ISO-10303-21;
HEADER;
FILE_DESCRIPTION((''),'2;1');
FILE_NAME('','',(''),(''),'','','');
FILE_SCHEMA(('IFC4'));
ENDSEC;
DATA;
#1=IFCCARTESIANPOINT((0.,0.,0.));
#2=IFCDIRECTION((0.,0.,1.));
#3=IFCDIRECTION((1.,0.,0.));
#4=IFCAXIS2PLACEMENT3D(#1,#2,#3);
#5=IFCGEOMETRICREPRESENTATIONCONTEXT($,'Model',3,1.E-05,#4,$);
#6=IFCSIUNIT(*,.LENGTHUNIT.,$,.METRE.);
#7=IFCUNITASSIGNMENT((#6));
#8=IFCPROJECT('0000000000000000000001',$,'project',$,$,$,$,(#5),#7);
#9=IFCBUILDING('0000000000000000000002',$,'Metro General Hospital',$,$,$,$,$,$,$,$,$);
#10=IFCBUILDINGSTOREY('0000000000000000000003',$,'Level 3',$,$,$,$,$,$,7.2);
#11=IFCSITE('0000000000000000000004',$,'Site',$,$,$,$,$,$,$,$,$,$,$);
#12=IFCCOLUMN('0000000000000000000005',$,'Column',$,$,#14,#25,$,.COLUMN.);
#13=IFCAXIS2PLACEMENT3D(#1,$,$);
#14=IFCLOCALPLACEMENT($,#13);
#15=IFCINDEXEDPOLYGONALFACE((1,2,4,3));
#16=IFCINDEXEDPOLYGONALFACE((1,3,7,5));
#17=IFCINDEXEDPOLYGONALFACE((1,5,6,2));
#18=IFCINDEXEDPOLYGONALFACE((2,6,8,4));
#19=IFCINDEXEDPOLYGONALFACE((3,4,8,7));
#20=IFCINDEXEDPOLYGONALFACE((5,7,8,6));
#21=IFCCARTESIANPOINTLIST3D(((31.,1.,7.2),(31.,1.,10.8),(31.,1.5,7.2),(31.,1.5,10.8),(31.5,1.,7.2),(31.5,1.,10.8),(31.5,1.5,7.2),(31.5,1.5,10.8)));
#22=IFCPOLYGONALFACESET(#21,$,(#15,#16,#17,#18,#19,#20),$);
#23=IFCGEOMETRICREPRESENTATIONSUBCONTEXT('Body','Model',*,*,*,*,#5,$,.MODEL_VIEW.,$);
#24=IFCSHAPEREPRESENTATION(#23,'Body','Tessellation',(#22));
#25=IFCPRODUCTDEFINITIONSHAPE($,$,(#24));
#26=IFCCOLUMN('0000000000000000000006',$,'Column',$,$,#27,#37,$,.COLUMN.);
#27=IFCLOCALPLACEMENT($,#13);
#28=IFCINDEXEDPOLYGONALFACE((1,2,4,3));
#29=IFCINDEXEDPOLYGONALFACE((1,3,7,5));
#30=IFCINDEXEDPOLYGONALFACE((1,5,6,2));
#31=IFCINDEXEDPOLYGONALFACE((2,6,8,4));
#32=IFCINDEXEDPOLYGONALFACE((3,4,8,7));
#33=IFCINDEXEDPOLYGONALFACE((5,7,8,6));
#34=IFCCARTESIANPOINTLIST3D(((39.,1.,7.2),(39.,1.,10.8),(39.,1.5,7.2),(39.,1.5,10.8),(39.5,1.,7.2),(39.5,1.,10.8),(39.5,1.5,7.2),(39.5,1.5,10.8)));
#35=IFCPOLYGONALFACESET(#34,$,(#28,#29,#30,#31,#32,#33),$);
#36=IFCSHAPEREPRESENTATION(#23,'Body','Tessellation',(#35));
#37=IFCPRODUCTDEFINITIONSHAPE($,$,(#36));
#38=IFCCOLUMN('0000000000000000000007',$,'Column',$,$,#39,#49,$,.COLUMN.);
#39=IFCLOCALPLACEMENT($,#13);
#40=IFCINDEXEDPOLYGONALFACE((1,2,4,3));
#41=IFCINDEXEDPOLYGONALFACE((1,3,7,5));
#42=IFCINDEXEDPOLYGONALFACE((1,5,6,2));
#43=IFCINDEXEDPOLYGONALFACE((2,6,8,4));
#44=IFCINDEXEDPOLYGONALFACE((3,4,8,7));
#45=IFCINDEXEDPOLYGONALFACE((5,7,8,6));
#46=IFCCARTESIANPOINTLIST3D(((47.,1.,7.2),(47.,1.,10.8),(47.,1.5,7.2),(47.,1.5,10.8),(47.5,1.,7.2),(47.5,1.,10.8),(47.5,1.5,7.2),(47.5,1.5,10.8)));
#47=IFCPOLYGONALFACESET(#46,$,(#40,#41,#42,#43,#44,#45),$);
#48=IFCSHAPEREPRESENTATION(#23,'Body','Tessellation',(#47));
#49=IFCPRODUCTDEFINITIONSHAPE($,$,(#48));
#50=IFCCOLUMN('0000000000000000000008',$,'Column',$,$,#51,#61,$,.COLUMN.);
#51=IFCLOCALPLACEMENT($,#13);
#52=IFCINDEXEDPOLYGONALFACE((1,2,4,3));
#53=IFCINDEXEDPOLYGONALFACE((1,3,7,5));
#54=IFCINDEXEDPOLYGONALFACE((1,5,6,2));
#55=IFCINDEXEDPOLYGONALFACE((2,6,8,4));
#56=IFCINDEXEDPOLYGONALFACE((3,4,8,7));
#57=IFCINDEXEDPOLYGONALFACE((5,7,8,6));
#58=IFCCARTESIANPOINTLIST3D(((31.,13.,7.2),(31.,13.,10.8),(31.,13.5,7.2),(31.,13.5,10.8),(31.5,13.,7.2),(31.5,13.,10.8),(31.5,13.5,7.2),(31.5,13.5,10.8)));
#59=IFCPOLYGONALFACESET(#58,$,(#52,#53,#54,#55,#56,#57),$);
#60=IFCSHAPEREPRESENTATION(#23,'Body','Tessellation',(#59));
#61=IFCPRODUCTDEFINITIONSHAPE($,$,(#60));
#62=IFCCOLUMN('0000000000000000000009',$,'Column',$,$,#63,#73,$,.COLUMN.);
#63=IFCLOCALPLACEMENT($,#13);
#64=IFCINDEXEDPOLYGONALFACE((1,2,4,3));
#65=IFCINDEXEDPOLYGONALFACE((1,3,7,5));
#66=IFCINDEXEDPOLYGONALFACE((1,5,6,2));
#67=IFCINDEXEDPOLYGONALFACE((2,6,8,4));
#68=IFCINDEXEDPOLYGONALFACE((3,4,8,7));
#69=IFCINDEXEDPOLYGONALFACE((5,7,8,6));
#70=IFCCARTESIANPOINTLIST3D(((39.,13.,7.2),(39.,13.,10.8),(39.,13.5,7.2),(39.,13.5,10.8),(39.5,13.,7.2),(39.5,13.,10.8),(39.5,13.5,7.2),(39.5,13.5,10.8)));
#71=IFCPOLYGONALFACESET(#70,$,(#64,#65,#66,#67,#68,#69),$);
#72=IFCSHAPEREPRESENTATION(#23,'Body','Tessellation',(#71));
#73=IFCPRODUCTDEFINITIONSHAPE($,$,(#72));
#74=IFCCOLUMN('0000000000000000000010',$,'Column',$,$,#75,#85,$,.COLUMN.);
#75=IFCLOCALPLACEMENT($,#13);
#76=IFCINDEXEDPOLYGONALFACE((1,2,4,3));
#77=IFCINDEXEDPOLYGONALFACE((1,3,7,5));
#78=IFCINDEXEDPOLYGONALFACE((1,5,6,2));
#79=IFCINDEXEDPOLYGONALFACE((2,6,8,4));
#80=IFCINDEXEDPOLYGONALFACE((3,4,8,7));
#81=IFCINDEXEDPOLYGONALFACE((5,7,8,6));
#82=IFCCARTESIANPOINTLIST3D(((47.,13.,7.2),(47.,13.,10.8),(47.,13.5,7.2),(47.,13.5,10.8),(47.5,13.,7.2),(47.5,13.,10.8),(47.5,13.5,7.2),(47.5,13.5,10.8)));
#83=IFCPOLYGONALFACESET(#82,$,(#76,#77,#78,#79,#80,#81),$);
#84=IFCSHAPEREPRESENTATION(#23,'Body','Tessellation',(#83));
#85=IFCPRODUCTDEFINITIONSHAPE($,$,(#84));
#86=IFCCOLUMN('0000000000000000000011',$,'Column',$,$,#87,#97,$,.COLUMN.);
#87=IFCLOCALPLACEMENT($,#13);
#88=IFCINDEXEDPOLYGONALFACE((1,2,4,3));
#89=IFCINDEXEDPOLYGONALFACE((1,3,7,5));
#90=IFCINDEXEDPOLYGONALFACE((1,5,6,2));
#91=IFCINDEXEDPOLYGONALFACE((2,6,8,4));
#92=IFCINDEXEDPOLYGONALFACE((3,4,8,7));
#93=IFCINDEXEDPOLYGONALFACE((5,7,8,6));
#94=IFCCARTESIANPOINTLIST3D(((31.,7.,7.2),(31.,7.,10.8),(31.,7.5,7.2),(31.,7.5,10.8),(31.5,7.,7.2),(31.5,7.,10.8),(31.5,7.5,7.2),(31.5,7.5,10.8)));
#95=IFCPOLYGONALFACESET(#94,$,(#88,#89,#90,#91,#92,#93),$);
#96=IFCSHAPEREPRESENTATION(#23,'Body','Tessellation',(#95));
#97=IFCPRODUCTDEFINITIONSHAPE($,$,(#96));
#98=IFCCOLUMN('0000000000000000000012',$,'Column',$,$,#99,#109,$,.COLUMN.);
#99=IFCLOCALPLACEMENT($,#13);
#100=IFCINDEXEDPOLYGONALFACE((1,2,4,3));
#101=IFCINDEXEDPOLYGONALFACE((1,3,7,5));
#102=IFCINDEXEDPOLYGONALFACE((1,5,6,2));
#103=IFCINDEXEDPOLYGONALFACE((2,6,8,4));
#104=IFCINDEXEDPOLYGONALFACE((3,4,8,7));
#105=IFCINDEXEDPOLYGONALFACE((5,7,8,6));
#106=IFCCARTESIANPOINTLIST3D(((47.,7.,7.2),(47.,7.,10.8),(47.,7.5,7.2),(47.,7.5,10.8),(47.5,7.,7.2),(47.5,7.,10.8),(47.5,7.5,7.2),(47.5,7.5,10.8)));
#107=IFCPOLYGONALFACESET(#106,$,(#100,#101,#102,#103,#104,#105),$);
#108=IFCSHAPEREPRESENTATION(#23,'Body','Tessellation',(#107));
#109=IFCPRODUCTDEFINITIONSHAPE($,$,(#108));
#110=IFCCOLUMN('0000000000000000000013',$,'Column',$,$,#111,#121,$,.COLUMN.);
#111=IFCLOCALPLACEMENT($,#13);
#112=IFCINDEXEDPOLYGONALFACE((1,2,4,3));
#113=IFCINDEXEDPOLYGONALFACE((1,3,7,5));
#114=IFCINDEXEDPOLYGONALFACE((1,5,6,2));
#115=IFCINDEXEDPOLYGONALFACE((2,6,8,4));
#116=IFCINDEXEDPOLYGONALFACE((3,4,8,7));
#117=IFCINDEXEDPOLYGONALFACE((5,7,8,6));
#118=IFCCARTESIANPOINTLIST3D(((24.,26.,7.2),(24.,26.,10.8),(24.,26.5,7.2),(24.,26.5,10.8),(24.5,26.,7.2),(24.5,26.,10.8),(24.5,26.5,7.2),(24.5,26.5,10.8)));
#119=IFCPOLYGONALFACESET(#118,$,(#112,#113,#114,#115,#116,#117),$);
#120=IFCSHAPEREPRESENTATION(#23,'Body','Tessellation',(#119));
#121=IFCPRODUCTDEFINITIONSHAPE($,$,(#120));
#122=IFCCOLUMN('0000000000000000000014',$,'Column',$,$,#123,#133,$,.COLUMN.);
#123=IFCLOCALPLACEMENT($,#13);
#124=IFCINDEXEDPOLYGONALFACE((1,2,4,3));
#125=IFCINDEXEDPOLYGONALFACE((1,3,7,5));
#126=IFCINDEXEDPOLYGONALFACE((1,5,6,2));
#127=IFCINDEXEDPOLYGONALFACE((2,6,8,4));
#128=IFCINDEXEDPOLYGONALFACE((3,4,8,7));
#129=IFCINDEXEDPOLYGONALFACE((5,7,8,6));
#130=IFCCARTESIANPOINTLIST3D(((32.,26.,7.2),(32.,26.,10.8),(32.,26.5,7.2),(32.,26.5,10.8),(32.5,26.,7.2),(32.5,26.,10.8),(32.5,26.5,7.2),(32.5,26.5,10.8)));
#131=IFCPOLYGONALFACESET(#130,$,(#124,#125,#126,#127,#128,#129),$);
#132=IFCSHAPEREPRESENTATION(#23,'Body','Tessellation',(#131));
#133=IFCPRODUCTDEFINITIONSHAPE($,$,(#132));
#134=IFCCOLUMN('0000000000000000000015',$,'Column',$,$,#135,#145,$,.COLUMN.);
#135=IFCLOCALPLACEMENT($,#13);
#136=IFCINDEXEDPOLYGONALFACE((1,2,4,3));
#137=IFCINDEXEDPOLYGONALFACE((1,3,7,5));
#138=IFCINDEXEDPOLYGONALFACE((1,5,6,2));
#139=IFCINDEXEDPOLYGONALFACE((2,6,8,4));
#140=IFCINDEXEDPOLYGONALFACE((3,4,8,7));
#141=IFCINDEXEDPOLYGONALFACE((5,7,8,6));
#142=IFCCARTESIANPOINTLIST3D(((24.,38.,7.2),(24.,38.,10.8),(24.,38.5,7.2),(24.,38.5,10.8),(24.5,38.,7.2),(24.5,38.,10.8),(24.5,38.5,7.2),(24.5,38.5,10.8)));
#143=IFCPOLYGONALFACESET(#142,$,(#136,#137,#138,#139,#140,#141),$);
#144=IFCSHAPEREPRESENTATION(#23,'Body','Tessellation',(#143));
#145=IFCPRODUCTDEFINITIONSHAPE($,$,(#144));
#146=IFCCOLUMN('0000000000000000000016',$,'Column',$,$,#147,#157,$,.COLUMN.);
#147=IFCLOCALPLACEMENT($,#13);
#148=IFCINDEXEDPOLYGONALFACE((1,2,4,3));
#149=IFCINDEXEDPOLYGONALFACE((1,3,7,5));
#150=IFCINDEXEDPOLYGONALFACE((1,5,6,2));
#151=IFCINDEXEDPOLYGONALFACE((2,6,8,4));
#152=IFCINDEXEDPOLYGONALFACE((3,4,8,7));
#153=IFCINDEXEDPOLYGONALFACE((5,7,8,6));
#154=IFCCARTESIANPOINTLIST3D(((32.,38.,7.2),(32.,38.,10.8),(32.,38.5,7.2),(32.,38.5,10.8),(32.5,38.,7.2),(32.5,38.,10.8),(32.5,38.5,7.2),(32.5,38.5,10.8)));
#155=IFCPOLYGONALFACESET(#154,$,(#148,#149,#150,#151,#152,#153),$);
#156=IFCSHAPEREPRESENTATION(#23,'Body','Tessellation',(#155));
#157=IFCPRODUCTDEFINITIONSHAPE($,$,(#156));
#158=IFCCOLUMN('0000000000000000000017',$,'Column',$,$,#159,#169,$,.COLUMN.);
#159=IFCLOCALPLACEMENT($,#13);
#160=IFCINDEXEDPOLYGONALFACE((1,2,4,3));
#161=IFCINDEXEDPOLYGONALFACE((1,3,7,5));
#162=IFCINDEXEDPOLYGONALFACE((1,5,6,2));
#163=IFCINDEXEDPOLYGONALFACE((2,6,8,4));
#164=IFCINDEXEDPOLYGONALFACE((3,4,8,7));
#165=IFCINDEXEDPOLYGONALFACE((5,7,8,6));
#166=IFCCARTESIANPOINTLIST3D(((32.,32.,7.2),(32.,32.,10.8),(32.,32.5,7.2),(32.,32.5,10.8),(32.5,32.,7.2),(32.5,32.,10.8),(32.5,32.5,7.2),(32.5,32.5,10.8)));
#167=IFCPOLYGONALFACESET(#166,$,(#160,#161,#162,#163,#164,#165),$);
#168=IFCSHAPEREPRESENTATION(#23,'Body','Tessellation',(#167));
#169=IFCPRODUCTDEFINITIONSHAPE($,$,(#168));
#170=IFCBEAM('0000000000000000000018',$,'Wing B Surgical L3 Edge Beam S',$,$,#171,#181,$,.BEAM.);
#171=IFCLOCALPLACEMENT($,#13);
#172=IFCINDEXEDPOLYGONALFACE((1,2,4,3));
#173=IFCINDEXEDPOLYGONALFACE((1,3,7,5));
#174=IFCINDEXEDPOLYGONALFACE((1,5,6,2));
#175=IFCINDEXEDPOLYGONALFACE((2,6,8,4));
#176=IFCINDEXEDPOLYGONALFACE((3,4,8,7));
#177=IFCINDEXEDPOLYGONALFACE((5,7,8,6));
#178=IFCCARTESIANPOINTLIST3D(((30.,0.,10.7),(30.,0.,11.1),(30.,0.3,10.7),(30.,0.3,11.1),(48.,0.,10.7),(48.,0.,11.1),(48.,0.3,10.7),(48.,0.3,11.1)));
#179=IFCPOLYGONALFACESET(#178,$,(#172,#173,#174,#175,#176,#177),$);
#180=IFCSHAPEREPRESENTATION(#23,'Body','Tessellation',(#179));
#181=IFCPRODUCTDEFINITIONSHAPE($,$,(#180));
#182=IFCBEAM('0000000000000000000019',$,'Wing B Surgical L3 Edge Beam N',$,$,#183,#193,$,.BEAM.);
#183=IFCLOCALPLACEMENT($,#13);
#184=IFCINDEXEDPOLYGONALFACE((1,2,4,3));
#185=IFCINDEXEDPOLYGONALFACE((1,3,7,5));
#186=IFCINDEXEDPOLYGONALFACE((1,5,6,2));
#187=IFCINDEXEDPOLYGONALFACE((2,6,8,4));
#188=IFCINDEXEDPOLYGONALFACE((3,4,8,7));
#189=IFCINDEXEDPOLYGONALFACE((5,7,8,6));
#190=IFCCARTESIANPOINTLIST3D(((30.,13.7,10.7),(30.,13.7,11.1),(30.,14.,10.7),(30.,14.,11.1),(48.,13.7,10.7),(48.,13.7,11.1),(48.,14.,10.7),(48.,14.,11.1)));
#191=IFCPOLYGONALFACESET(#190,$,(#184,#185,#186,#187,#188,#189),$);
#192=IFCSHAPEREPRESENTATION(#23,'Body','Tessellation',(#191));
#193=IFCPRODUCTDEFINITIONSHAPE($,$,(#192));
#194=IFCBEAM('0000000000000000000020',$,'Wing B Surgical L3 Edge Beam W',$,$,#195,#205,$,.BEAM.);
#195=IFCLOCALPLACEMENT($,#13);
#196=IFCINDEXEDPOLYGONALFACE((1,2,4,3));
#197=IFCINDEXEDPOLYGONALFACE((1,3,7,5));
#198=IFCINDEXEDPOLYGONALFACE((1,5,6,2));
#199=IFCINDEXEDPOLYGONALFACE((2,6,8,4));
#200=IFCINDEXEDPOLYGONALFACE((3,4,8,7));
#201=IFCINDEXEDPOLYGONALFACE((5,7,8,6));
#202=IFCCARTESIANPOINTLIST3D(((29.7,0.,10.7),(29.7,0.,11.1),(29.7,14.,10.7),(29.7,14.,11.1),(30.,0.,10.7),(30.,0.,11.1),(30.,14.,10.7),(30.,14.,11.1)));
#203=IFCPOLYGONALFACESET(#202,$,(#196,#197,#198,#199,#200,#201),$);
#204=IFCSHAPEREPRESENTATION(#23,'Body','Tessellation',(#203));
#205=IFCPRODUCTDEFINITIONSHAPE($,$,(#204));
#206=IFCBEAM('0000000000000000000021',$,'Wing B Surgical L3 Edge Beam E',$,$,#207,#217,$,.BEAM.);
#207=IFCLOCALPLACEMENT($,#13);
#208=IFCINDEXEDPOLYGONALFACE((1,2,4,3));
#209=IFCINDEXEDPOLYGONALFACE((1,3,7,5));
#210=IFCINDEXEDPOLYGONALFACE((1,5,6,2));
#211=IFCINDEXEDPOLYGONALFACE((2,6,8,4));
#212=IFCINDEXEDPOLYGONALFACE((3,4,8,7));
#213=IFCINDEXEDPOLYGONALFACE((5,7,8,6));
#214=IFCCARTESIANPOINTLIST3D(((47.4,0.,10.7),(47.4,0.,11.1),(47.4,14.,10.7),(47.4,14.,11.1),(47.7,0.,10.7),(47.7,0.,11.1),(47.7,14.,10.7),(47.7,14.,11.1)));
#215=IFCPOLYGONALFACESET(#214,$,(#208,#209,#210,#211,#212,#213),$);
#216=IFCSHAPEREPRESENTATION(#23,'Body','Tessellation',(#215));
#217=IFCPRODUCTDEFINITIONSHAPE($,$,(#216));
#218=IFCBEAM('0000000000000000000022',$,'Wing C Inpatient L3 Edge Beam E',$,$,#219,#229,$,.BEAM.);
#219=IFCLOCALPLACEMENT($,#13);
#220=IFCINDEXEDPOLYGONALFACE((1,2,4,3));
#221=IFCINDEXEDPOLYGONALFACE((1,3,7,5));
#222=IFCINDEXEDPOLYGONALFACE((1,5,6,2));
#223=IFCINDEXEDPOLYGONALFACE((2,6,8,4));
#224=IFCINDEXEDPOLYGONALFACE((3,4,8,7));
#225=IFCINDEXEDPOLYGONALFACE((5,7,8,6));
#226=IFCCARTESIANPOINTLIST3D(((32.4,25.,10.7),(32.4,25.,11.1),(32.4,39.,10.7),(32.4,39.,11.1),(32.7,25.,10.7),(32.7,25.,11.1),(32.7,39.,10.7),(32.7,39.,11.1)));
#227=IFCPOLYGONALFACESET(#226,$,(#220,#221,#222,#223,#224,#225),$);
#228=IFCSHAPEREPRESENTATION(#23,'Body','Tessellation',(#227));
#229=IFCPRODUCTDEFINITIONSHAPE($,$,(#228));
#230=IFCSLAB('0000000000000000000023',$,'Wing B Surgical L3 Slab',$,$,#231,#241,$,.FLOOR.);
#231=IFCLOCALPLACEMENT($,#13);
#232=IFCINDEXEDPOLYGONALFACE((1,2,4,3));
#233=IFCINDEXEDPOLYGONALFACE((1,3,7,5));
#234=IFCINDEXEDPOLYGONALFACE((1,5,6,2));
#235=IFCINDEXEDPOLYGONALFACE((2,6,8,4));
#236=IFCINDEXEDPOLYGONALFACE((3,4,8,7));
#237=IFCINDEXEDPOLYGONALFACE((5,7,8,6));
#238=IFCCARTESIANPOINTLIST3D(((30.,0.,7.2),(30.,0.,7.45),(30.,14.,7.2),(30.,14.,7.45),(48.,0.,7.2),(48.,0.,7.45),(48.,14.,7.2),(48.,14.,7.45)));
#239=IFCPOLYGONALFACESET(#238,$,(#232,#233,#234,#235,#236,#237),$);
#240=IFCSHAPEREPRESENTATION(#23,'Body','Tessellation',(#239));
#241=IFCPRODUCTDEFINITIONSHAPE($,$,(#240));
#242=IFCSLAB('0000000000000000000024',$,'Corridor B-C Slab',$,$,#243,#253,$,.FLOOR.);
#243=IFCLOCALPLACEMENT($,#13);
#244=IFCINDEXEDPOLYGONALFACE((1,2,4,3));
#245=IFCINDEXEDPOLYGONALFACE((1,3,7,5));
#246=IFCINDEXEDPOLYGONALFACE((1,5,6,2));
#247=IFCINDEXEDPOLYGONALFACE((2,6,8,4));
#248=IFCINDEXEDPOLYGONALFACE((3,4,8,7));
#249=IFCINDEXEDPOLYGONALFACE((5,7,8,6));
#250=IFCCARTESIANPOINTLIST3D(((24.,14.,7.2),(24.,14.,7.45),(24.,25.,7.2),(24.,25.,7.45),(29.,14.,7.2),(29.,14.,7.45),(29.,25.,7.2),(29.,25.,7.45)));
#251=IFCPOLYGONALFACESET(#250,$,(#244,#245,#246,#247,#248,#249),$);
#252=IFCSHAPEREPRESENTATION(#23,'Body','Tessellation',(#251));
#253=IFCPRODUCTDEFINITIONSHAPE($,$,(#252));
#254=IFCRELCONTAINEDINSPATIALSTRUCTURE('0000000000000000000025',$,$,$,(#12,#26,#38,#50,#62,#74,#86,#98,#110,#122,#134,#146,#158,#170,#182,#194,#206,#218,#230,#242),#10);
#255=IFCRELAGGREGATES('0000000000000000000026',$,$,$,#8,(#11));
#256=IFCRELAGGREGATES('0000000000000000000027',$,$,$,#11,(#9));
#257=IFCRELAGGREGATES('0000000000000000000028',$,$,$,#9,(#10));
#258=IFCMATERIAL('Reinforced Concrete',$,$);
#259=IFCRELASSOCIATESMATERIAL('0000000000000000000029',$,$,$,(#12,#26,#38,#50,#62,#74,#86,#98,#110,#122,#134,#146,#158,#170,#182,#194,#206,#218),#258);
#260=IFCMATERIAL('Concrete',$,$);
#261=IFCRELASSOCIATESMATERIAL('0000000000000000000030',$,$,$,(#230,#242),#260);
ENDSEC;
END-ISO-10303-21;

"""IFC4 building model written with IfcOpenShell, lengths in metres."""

from ifc_helpers import new_model, si_unit, frame, origin_with_axes, place, context, subcontext, project, spatial, line, indexed_curve, outline, extrude, material, element, save


model = new_model("IFC4")

# Units and contexts
model_context = context("Model", 3, precision=1e-05, world=origin_with_axes())
body_context = subcontext(model_context, "Body", "Model", "MODEL_VIEW")
ifc_project = project(units=[si_unit("LENGTHUNIT", "METRE")], contexts=[model_context])

# Site, building, storey
site = spatial("IfcSite", under=ifc_project, Name="Site")
building = spatial("IfcBuilding", under=site, Name="Metro General Hospital")
storey = spatial("IfcBuildingStorey", under=building, Name="Level 3", Elevation=7.2)

# Columns
ifc_material_1 = material(Name="Reinforced Concrete")
for number, where, z_axis, x_axis, name in (
    (1, (31.0, 1.0, 7.2), (0.0, 0.0, 1.0), (1.0, 0.0, 0.0), "Column"),
    (2, (39.0, 1.0, 7.2), (0.0, 0.0, 1.0), (1.0, 0.0, 0.0), "Column"),
    (3, (47.0, 1.0, 7.2), (0.0, 0.0, 1.0), (1.0, 0.0, 0.0), "Column"),
    (4, (31.0, 13.0, 7.2), (0.0, 0.0, 1.0), (1.0, 0.0, 0.0), "Column"),
    (5, (39.0, 13.0, 7.2), (0.0, 0.0, 1.0), (1.0, 0.0, 0.0), "Column"),
    (6, (47.0, 13.0, 7.2), (0.0, 0.0, 1.0), (1.0, 0.0, 0.0), "Column"),
    (7, (31.0, 7.0, 7.2), (0.0, 0.0, 1.0), (1.0, 0.0, 0.0), "Column"),
    (8, (47.0, 7.0, 7.2), (0.0, 0.0, 1.0), (1.0, 0.0, 0.0), "Column"),
    (9, (24.0, 26.0, 7.2), (0.0, 0.0, 1.0), (1.0, 0.0, 0.0), "Column"),
    (10, (32.0, 26.0, 7.2), (0.0, 0.0, 1.0), (1.0, 0.0, 0.0), "Column"),
    (11, (24.0, 38.0, 7.2), (0.0, 0.0, 1.0), (1.0, 0.0, 0.0), "Column"),
    (12, (32.0, 38.0, 7.2), (0.0, 0.0, 1.0), (1.0, 0.0, 0.0), "Column"),
    (13, (32.0, 32.0, 7.2), (0.0, 0.0, 1.0), (1.0, 0.0, 0.0), "Column"),
):
    element("IfcColumn", number, at=place(None, frame(where, z_axis=z_axis, x_axis=x_axis)), inside=storey, material=ifc_material_1, Name=name, PredefinedType="COLUMN", context=body_context, shape_type="SweptSolid", body=[
        extrude(outline(indexed_curve([(0.0, 0.0), (0.5, 0.0), (0.5, 0.5), (0.0, 0.5)], segments=[line(1, 2, 3, 4, 1)])), origin_with_axes(), (0.0, 0.0, 1.0), 3.6),
    ])

# Beams
for number, where, z_axis, x_axis, name in (
    (14, (30.0, 0.0, 10.7), (0.0, 0.0, 1.0), (1.0, 0.0, 0.0), "Wing B Surgical L3 Edge Beam S"),
    (15, (30.0, 13.7, 10.7), (0.0, 0.0, 1.0), (1.0, 0.0, 0.0), "Wing B Surgical L3 Edge Beam N"),
):
    element("IfcBeam", number, at=place(None, frame(where, z_axis=z_axis, x_axis=x_axis)), inside=storey, material=ifc_material_1, Name=name, PredefinedType="BEAM", context=body_context, shape_type="SweptSolid", body=[
        extrude(outline(indexed_curve([(0.0, 0.0), (18.0, 0.0), (18.0, 0.3), (0.0, 0.3)], segments=[line(1, 2, 3, 4, 1)])), origin_with_axes(), (0.0, 0.0, 1.0), 0.4),
    ])
for number, where, z_axis, x_axis, name in (
    (16, (30.0, 0.0, 10.7), (0.0, 0.0, 1.0), (0.0, 1.0, 0.0), "Wing B Surgical L3 Edge Beam W"),
    (17, (47.7, 0.0, 10.7), (0.0, 0.0, 1.0), (0.0, 1.0, 0.0), "Wing B Surgical L3 Edge Beam E"),
    (18, (32.7, 25.0, 10.7), (0.0, 0.0, 1.0), (0.0, 1.0, 0.0), "Wing C Inpatient L3 Edge Beam E"),
):
    element("IfcBeam", number, at=place(None, frame(where, z_axis=z_axis, x_axis=x_axis)), inside=storey, material=ifc_material_1, Name=name, PredefinedType="BEAM", context=body_context, shape_type="SweptSolid", body=[
        extrude(outline(indexed_curve([(0.0, 0.0), (14.0, 0.0), (14.0, 0.3), (0.0, 0.3)], segments=[line(1, 2, 3, 4, 1)])), origin_with_axes(), (0.0, 0.0, 1.0), 0.4),
    ])

# Slabs
ifc_material_2 = material(Name="Concrete")
slab_1_placement = place(None, frame((30.0, 0.0, 7.2), z_axis=(0.0, 0.0, 1.0), x_axis=(1.0, 0.0, 0.0)))
element("IfcSlab", 19, at=slab_1_placement, inside=storey, material=ifc_material_2, Name="Wing B Surgical L3 Slab", PredefinedType="FLOOR", context=body_context, shape_type="SweptSolid", body=[
    extrude(outline(indexed_curve([(0.0, 0.0), (18.0, 0.0), (18.0, 14.0), (0.0, 14.0)], segments=[line(1, 2, 3, 4, 1)])), origin_with_axes(), (0.0, 0.0, 1.0), 0.25),
])
slab_2_placement = place(None, frame((24.0, 14.0, 7.2), z_axis=(0.0, 0.0, 1.0), x_axis=(1.0, 0.0, 0.0)))
element("IfcSlab", 20, at=slab_2_placement, inside=storey, material=ifc_material_2, Name="Corridor B-C Slab", PredefinedType="FLOOR", context=body_context, shape_type="SweptSolid", body=[
    extrude(outline(indexed_curve([(0.0, 0.0), (5.0, 0.0), (5.0, 11.0), (0.0, 11.0)], segments=[line(1, 2, 3, 4, 1)])), origin_with_axes(), (0.0, 0.0, 1.0), 0.25),
])

save(model, "model.ifc")
